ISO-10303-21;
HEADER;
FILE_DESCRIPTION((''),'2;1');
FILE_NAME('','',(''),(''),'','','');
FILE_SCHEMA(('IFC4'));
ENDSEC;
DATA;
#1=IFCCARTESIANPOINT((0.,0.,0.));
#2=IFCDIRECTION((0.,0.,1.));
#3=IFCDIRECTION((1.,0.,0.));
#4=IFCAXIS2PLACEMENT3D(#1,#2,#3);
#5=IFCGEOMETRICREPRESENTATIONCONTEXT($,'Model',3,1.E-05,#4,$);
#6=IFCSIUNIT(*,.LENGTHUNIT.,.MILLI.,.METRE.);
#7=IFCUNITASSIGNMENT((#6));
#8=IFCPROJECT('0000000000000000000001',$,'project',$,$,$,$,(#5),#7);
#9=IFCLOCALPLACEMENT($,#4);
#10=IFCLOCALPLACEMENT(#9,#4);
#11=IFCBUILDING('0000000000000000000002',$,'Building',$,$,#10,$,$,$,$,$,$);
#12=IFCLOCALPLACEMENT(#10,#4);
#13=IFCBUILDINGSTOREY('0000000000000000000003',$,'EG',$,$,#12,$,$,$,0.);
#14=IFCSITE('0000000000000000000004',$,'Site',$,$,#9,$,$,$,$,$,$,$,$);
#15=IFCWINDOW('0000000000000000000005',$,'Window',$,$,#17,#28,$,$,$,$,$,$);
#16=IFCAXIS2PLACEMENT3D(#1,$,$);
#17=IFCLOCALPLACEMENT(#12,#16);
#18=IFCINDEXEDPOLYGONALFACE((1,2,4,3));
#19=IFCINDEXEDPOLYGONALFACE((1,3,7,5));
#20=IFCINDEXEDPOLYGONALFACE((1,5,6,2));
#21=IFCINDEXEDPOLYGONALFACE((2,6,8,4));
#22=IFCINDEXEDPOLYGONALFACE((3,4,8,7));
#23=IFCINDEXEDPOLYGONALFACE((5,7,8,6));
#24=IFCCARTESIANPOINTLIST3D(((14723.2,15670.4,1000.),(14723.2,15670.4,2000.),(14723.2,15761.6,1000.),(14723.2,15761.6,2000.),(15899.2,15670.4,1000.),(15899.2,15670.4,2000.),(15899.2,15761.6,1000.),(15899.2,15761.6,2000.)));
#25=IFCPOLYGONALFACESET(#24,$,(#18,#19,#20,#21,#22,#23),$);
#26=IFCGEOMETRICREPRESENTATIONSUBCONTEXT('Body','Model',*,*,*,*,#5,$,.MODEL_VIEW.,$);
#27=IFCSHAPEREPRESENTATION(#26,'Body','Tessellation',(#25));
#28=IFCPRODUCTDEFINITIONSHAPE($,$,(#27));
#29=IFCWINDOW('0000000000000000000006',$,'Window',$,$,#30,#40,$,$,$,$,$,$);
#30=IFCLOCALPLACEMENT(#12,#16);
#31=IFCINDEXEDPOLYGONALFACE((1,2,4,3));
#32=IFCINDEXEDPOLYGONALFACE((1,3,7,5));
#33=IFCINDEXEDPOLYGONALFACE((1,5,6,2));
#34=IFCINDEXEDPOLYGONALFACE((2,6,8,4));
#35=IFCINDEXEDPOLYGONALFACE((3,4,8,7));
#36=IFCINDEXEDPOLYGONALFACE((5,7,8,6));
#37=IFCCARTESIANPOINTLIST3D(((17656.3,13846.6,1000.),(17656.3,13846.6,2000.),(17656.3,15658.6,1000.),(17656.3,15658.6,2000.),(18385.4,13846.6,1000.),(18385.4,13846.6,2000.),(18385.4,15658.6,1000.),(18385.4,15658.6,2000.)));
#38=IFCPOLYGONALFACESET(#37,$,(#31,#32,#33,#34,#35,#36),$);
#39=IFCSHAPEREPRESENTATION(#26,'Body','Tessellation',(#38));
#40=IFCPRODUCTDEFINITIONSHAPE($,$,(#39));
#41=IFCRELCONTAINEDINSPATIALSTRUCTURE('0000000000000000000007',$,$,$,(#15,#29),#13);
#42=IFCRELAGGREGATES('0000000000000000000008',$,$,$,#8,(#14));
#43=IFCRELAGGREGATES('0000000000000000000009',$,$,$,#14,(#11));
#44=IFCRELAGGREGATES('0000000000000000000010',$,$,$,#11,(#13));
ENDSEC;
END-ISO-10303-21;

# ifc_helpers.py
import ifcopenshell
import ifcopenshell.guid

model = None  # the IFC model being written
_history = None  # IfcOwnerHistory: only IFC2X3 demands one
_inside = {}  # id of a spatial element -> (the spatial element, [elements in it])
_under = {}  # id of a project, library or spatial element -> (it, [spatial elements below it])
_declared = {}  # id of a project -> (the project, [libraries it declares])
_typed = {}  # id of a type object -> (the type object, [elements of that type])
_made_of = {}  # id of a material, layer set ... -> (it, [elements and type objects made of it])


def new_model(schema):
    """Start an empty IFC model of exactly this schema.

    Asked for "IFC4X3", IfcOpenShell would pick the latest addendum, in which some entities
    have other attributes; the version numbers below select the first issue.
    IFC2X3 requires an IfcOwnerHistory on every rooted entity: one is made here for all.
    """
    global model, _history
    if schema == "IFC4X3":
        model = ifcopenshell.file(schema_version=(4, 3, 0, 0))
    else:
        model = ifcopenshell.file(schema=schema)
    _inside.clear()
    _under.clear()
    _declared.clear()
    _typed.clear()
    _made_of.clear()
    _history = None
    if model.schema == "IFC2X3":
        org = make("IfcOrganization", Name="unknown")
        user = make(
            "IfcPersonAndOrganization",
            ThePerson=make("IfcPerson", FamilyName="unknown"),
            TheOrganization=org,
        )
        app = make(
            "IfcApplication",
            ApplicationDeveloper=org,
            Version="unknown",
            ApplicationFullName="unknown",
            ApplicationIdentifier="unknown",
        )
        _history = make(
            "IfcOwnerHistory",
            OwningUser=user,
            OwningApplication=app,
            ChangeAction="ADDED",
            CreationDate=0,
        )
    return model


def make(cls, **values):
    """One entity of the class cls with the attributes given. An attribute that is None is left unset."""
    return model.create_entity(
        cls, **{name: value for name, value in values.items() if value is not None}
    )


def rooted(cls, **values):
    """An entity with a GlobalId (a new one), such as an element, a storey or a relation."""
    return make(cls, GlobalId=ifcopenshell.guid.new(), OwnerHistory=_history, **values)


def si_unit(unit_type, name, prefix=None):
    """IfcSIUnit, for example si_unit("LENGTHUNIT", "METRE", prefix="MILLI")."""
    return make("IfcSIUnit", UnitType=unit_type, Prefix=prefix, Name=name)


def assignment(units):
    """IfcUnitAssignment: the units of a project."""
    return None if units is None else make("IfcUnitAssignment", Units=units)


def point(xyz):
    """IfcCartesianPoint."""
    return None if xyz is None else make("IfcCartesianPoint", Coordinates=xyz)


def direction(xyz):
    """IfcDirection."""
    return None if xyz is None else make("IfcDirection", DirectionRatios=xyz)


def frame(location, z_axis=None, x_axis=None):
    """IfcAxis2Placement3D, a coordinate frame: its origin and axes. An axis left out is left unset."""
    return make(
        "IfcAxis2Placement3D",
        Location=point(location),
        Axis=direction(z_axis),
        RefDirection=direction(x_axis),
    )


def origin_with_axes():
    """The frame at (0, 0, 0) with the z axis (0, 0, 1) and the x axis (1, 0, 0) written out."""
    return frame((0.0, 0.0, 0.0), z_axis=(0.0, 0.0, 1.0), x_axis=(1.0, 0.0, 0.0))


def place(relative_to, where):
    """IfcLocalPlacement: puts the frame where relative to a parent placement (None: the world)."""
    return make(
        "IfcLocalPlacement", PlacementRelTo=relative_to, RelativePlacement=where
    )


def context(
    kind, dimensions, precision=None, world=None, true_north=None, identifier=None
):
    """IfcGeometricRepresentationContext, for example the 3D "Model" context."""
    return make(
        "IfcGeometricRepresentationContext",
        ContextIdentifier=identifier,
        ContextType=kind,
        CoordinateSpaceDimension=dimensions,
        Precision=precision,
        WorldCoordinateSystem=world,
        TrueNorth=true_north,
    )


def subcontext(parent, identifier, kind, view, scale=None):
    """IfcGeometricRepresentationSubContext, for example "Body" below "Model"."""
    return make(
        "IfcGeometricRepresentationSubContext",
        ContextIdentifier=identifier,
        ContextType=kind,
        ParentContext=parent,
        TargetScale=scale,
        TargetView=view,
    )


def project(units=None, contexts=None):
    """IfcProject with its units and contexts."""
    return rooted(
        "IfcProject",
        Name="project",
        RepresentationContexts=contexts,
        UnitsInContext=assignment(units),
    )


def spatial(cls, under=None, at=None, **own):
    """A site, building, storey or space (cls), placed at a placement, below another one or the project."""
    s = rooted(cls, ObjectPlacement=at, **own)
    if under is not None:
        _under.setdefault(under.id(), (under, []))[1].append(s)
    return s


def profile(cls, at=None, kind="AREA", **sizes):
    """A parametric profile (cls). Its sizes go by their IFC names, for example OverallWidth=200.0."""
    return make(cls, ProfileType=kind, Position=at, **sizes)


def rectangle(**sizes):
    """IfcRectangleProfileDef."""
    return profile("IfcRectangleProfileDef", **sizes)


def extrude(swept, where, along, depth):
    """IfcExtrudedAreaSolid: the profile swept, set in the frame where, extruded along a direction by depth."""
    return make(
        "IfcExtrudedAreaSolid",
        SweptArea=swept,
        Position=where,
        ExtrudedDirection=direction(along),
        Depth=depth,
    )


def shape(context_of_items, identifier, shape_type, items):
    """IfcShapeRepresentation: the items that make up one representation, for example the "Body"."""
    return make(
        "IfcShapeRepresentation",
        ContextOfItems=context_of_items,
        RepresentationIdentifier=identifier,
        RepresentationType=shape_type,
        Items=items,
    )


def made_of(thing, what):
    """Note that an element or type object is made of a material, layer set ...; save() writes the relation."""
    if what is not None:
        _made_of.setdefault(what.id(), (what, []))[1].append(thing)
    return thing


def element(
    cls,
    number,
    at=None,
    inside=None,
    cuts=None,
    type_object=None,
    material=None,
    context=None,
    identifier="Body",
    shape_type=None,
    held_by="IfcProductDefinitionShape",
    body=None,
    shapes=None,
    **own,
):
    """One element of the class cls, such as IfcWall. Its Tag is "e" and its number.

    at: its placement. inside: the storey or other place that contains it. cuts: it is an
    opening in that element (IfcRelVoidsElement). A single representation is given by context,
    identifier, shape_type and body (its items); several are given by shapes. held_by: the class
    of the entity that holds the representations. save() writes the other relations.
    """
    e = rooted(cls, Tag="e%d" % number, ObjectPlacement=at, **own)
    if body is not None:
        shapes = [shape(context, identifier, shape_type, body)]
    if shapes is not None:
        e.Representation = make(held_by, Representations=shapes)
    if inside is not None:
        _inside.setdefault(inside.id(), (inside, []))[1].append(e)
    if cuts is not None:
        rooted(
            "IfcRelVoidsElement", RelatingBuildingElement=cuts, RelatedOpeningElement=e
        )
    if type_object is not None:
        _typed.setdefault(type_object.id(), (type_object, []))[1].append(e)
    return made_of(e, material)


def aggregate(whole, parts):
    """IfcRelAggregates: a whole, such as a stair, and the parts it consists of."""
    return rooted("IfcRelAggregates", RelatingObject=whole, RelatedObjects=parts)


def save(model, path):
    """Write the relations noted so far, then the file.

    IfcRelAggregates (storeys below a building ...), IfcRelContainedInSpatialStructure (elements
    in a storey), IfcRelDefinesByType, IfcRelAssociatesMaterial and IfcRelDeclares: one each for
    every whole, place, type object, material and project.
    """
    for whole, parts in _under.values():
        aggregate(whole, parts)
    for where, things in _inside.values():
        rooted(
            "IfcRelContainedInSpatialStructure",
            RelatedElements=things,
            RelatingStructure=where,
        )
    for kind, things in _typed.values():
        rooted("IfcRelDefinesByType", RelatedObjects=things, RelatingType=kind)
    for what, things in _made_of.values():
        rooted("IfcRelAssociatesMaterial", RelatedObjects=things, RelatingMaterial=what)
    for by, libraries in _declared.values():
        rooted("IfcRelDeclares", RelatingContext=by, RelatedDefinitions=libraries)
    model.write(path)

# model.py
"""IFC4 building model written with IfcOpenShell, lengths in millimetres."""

from ifc_helpers import new_model, si_unit, frame, origin_with_axes, place, context, subcontext, project, spatial, rectangle, extrude, element, save


model = new_model("IFC4")

# Units and contexts
model_context = context("Model", 3, precision=1e-05, world=origin_with_axes())
body_context = subcontext(model_context, "Body", "Model", "MODEL_VIEW")
ifc_project = project(units=[si_unit("LENGTHUNIT", "METRE", prefix="MILLI")], contexts=[model_context])

# Site, building, storey
site_placement = place(None, origin_with_axes())
site = spatial("IfcSite", under=ifc_project, at=site_placement, Name="Site")
building_placement = place(site_placement, origin_with_axes())
building = spatial("IfcBuilding", under=site, at=building_placement, Name="Building")
storey_placement = place(building_placement, origin_with_axes())
storey = spatial("IfcBuildingStorey", under=building, at=storey_placement, Name="EG", Elevation=0.0)

# Windows
window_1_placement = place(storey_placement, origin_with_axes())
element("IfcWindow", 1, at=window_1_placement, inside=storey, Name="Window", context=body_context, shape_type="SweptSolid", body=[
    extrude(rectangle(XDim=1176.0, YDim=91.1), frame((15311.2, 15716.0, 1000.0), z_axis=(0.0, 0.0, 1.0), x_axis=(1.0, 0.0, 0.0)), (0.0, 0.0, 1.0), 1000.0),
])
window_2_placement = place(storey_placement, origin_with_axes())
element("IfcWindow", 2, at=window_2_placement, inside=storey, Name="Window", context=body_context, shape_type="SweptSolid", body=[
    extrude(rectangle(XDim=1812.0, YDim=729.2), frame((18020.8, 14752.6, 1000.0), z_axis=(0.0, 0.0, 1.0), x_axis=(0.0, 1.0, 0.0)), (0.0, 0.0, 1.0), 1000.0),
])

save(model, "model.ifc")
